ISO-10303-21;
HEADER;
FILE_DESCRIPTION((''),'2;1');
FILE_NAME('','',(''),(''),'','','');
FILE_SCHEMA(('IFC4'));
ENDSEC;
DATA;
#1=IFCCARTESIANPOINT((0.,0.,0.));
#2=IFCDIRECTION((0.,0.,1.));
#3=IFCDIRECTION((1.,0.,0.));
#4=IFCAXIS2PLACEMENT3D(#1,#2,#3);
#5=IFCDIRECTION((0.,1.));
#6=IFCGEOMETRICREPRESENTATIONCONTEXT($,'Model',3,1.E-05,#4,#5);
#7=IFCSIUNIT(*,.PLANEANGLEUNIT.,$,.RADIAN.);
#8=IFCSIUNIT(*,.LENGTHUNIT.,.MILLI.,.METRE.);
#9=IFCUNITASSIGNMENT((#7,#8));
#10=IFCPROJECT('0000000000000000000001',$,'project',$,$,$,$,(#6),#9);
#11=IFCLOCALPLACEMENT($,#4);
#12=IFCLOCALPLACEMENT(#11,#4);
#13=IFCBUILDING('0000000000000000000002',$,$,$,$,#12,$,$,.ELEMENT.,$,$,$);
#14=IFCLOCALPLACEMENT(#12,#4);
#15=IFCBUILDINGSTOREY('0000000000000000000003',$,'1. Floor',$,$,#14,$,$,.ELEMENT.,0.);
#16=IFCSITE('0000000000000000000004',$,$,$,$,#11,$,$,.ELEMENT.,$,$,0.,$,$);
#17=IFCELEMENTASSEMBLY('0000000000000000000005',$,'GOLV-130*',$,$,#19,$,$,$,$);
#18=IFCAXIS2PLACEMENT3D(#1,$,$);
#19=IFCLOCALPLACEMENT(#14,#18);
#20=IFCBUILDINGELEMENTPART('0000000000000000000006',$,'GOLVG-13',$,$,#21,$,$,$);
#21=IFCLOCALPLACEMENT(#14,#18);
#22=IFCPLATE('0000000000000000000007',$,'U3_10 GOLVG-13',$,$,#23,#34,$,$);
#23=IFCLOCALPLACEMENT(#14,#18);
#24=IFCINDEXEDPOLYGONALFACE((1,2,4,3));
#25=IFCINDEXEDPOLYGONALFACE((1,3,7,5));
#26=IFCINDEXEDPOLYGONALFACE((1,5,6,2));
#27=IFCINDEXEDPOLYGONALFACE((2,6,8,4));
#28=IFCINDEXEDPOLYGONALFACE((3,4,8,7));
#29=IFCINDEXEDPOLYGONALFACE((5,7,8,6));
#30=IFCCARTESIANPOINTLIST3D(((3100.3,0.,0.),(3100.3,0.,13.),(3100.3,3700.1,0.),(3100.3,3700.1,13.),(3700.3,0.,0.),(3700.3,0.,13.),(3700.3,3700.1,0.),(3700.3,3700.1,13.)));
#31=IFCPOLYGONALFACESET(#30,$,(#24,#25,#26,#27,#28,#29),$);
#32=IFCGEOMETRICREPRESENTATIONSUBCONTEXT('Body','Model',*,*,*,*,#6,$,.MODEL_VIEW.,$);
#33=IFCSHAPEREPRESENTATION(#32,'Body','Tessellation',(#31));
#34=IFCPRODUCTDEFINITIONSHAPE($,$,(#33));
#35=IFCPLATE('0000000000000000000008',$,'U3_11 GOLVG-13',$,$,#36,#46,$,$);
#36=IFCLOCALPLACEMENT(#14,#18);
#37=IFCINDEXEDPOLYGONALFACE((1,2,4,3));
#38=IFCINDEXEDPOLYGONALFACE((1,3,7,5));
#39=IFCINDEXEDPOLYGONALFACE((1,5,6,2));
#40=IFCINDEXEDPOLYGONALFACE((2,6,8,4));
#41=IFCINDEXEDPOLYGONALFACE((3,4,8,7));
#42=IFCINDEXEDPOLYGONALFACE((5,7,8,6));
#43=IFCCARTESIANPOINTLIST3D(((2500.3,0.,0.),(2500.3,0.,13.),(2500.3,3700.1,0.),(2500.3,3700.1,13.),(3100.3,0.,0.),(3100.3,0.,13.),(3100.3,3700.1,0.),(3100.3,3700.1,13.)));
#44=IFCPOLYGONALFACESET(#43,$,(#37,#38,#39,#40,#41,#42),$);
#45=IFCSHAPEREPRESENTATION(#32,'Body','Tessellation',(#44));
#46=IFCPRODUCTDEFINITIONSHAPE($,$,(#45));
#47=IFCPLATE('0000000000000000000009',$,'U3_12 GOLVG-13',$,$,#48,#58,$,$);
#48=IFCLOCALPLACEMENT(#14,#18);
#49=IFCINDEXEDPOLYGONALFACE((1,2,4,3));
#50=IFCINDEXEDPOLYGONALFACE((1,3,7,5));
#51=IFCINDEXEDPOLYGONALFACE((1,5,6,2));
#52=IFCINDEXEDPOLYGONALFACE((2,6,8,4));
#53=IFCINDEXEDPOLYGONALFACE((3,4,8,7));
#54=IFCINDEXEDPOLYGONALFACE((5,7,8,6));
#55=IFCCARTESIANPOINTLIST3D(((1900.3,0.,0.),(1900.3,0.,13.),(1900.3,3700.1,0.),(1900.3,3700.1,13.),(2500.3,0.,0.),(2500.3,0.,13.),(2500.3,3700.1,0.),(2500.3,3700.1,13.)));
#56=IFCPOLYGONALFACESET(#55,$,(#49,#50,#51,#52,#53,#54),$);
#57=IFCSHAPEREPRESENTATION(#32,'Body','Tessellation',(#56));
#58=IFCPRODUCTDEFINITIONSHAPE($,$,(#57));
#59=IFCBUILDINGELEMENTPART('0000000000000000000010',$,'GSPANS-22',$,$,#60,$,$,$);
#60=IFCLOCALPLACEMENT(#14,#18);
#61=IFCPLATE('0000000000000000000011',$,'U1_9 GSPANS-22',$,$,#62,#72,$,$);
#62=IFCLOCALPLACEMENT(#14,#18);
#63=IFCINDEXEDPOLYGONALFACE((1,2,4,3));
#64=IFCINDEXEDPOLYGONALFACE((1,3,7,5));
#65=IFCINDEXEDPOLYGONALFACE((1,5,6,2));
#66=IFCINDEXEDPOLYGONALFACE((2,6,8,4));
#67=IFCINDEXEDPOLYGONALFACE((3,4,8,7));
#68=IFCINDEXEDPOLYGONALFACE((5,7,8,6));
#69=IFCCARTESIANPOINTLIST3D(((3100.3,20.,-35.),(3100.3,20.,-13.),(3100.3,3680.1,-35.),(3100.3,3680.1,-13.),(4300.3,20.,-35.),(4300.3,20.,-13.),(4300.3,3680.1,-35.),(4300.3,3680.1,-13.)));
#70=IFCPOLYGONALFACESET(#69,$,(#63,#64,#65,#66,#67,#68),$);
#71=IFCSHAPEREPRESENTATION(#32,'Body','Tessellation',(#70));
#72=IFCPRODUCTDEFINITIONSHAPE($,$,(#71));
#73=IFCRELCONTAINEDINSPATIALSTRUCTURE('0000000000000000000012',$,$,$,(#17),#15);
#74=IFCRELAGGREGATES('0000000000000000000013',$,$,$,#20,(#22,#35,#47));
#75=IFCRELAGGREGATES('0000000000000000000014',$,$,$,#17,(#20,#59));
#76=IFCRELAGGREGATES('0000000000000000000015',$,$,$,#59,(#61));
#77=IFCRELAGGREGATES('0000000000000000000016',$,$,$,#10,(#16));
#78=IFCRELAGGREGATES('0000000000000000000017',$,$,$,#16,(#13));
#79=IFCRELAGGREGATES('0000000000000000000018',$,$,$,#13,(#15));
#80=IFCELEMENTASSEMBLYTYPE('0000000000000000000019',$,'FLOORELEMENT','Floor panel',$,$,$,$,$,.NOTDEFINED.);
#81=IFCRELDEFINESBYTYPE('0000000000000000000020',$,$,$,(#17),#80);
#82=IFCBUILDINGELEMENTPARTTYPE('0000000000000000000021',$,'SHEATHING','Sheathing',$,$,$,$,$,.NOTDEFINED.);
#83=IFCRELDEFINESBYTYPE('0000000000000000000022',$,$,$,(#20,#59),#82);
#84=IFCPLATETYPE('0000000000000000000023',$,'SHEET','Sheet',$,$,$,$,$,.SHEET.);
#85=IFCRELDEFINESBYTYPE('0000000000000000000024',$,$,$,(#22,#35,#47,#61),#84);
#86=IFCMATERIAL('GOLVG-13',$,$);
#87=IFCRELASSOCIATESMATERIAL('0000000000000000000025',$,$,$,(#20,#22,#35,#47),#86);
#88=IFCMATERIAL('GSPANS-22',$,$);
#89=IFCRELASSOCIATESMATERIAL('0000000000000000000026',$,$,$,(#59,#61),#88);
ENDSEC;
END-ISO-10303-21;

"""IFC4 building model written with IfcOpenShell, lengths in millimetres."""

from ifc_helpers import new_model, si_unit, direction, frame, origin_with_axes, origin_2d_with_axis, place, context, subcontext, project, spatial, rectangle, extrude, material, type_object, element, aggregate, save


model = new_model("IFC4")

# Units and contexts
model_context = context("Model", 3, precision=1e-05, world=origin_with_axes(), true_north=direction((0.0, 1.0)))
body_context = subcontext(model_context, "Body", "Model", "MODEL_VIEW")
ifc_project = project(units=[si_unit("PLANEANGLEUNIT", "RADIAN"), si_unit("LENGTHUNIT", "METRE", prefix="MILLI")], contexts=[model_context])

# Site, building, storey
site_placement = place(None, origin_with_axes())
site = spatial("IfcSite", under=ifc_project, at=site_placement, CompositionType="ELEMENT", RefElevation=0.0)
building_placement = place(site_placement, origin_with_axes())
building = spatial("IfcBuilding", under=site, at=building_placement, CompositionType="ELEMENT")
storey_placement = place(building_placement, origin_with_axes())
storey = spatial("IfcBuildingStorey", under=building, at=storey_placement, Name="1. Floor", CompositionType="ELEMENT", Elevation=0.0)

# Element assembly, building element parts, plates
element_assembly_type_1 = type_object("IfcElementAssemblyType", Name="FLOORELEMENT", Description="Floor panel", PredefinedType="NOTDEFINED")
assembly_1_placement = place(storey_placement, origin_with_axes())
assembly_1 = element("IfcElementAssembly", 1, at=assembly_1_placement, inside=storey, type_object=element_assembly_type_1, Name="GOLV-130*")
ifc_material_1 = material(Name="GOLVG-13")
building_element_part_type_1 = type_object("IfcBuildingElementPartType", Name="SHEATHING", Description="Sheathing", PredefinedType="NOTDEFINED")
building_element_part_1_placement = place(storey_placement, origin_with_axes())
building_element_part_1 = element("IfcBuildingElementPart", 2, at=building_element_part_1_placement, type_object=building_element_part_type_1, material=ifc_material_1, Name="GOLVG-13")
plate_type = type_object("IfcPlateType", Name="SHEET", Description="Sheet", PredefinedType="SHEET")
plate_1_placement = place(storey_placement, frame((3400.3, 1700.1, 13.0), z_axis=(0.0, 0.0, 1.0), x_axis=(-1.0, 0.0, 0.0)))
plate_1 = element("IfcPlate", 3, at=plate_1_placement, type_object=plate_type, material=ifc_material_1, Name="U3_10 GOLVG-13", context=body_context, shape_type="SweptSolid", body=[
    extrude(rectangle(XDim=13.0, YDim=600.0, at=origin_2d_with_axis()), frame((0.0, -2000.0, -6.5), z_axis=(0.0, 1.0, 0.0), x_axis=(0.0, 0.0, 1.0)), (0.0, 0.0, 1.0), 3700.1),
])
plate_2_placement = place(storey_placement, frame((2800.3, 1700.1, 13.0), z_axis=(0.0, 0.0, 1.0), x_axis=(-1.0, 0.0, 0.0)))
plate_2 = element("IfcPlate", 4, at=plate_2_placement, type_object=plate_type, material=ifc_material_1, Name="U3_11 GOLVG-13", context=body_context, shape_type="SweptSolid", body=[
    extrude(rectangle(XDim=13.0, YDim=600.0, at=origin_2d_with_axis()), frame((0.0, -2000.0, -6.5), z_axis=(0.0, 1.0, 0.0), x_axis=(0.0, 0.0, 1.0)), (0.0, 0.0, 1.0), 3700.1),
])
plate_3_placement = place(storey_placement, frame((2200.3, 1700.1, 13.0), z_axis=(0.0, 0.0, 1.0), x_axis=(-1.0, 0.0, 0.0)))
plate_3 = element("IfcPlate", 5, at=plate_3_placement, type_object=plate_type, material=ifc_material_1, Name="U3_12 GOLVG-13", context=body_context, shape_type="SweptSolid", body=[
    extrude(rectangle(XDim=13.0, YDim=600.0, at=origin_2d_with_axis()), frame((0.0, -2000.0, -6.5), z_axis=(0.0, 1.0, 0.0), x_axis=(0.0, 0.0, 1.0)), (0.0, 0.0, 1.0), 3700.1),
])
aggregate(building_element_part_1, [plate_1, plate_2, plate_3])
ifc_material_2 = material(Name="GSPANS-22")
building_element_part_2_placement = place(storey_placement, origin_with_axes())
building_element_part_2 = element("IfcBuildingElementPart", 6, at=building_element_part_2_placement, type_object=building_element_part_type_1, material=ifc_material_2, Name="GSPANS-22")
aggregate(assembly_1, [building_element_part_1, building_element_part_2])
plate_4_placement = place(storey_placement, frame((3700.3, 2020.0, -13.0), z_axis=(0.0, 0.0, 1.0), x_axis=(-1.0, 0.0, 0.0)))
plate_4 = element("IfcPlate", 7, at=plate_4_placement, type_object=plate_type, material=ifc_material_2, Name="U1_9 GSPANS-22", context=body_context, shape_type="SweptSolid", body=[
    extrude(rectangle(XDim=22.0, YDim=1200.0, at=origin_2d_with_axis()), frame((0.0, -1660.1, -11.0), z_axis=(0.0, 1.0, 0.0), x_axis=(0.0, 0.0, 1.0)), (0.0, 0.0, 1.0), 3660.1),
])
aggregate(building_element_part_2, [plate_4])

save(model, "model.ifc")
